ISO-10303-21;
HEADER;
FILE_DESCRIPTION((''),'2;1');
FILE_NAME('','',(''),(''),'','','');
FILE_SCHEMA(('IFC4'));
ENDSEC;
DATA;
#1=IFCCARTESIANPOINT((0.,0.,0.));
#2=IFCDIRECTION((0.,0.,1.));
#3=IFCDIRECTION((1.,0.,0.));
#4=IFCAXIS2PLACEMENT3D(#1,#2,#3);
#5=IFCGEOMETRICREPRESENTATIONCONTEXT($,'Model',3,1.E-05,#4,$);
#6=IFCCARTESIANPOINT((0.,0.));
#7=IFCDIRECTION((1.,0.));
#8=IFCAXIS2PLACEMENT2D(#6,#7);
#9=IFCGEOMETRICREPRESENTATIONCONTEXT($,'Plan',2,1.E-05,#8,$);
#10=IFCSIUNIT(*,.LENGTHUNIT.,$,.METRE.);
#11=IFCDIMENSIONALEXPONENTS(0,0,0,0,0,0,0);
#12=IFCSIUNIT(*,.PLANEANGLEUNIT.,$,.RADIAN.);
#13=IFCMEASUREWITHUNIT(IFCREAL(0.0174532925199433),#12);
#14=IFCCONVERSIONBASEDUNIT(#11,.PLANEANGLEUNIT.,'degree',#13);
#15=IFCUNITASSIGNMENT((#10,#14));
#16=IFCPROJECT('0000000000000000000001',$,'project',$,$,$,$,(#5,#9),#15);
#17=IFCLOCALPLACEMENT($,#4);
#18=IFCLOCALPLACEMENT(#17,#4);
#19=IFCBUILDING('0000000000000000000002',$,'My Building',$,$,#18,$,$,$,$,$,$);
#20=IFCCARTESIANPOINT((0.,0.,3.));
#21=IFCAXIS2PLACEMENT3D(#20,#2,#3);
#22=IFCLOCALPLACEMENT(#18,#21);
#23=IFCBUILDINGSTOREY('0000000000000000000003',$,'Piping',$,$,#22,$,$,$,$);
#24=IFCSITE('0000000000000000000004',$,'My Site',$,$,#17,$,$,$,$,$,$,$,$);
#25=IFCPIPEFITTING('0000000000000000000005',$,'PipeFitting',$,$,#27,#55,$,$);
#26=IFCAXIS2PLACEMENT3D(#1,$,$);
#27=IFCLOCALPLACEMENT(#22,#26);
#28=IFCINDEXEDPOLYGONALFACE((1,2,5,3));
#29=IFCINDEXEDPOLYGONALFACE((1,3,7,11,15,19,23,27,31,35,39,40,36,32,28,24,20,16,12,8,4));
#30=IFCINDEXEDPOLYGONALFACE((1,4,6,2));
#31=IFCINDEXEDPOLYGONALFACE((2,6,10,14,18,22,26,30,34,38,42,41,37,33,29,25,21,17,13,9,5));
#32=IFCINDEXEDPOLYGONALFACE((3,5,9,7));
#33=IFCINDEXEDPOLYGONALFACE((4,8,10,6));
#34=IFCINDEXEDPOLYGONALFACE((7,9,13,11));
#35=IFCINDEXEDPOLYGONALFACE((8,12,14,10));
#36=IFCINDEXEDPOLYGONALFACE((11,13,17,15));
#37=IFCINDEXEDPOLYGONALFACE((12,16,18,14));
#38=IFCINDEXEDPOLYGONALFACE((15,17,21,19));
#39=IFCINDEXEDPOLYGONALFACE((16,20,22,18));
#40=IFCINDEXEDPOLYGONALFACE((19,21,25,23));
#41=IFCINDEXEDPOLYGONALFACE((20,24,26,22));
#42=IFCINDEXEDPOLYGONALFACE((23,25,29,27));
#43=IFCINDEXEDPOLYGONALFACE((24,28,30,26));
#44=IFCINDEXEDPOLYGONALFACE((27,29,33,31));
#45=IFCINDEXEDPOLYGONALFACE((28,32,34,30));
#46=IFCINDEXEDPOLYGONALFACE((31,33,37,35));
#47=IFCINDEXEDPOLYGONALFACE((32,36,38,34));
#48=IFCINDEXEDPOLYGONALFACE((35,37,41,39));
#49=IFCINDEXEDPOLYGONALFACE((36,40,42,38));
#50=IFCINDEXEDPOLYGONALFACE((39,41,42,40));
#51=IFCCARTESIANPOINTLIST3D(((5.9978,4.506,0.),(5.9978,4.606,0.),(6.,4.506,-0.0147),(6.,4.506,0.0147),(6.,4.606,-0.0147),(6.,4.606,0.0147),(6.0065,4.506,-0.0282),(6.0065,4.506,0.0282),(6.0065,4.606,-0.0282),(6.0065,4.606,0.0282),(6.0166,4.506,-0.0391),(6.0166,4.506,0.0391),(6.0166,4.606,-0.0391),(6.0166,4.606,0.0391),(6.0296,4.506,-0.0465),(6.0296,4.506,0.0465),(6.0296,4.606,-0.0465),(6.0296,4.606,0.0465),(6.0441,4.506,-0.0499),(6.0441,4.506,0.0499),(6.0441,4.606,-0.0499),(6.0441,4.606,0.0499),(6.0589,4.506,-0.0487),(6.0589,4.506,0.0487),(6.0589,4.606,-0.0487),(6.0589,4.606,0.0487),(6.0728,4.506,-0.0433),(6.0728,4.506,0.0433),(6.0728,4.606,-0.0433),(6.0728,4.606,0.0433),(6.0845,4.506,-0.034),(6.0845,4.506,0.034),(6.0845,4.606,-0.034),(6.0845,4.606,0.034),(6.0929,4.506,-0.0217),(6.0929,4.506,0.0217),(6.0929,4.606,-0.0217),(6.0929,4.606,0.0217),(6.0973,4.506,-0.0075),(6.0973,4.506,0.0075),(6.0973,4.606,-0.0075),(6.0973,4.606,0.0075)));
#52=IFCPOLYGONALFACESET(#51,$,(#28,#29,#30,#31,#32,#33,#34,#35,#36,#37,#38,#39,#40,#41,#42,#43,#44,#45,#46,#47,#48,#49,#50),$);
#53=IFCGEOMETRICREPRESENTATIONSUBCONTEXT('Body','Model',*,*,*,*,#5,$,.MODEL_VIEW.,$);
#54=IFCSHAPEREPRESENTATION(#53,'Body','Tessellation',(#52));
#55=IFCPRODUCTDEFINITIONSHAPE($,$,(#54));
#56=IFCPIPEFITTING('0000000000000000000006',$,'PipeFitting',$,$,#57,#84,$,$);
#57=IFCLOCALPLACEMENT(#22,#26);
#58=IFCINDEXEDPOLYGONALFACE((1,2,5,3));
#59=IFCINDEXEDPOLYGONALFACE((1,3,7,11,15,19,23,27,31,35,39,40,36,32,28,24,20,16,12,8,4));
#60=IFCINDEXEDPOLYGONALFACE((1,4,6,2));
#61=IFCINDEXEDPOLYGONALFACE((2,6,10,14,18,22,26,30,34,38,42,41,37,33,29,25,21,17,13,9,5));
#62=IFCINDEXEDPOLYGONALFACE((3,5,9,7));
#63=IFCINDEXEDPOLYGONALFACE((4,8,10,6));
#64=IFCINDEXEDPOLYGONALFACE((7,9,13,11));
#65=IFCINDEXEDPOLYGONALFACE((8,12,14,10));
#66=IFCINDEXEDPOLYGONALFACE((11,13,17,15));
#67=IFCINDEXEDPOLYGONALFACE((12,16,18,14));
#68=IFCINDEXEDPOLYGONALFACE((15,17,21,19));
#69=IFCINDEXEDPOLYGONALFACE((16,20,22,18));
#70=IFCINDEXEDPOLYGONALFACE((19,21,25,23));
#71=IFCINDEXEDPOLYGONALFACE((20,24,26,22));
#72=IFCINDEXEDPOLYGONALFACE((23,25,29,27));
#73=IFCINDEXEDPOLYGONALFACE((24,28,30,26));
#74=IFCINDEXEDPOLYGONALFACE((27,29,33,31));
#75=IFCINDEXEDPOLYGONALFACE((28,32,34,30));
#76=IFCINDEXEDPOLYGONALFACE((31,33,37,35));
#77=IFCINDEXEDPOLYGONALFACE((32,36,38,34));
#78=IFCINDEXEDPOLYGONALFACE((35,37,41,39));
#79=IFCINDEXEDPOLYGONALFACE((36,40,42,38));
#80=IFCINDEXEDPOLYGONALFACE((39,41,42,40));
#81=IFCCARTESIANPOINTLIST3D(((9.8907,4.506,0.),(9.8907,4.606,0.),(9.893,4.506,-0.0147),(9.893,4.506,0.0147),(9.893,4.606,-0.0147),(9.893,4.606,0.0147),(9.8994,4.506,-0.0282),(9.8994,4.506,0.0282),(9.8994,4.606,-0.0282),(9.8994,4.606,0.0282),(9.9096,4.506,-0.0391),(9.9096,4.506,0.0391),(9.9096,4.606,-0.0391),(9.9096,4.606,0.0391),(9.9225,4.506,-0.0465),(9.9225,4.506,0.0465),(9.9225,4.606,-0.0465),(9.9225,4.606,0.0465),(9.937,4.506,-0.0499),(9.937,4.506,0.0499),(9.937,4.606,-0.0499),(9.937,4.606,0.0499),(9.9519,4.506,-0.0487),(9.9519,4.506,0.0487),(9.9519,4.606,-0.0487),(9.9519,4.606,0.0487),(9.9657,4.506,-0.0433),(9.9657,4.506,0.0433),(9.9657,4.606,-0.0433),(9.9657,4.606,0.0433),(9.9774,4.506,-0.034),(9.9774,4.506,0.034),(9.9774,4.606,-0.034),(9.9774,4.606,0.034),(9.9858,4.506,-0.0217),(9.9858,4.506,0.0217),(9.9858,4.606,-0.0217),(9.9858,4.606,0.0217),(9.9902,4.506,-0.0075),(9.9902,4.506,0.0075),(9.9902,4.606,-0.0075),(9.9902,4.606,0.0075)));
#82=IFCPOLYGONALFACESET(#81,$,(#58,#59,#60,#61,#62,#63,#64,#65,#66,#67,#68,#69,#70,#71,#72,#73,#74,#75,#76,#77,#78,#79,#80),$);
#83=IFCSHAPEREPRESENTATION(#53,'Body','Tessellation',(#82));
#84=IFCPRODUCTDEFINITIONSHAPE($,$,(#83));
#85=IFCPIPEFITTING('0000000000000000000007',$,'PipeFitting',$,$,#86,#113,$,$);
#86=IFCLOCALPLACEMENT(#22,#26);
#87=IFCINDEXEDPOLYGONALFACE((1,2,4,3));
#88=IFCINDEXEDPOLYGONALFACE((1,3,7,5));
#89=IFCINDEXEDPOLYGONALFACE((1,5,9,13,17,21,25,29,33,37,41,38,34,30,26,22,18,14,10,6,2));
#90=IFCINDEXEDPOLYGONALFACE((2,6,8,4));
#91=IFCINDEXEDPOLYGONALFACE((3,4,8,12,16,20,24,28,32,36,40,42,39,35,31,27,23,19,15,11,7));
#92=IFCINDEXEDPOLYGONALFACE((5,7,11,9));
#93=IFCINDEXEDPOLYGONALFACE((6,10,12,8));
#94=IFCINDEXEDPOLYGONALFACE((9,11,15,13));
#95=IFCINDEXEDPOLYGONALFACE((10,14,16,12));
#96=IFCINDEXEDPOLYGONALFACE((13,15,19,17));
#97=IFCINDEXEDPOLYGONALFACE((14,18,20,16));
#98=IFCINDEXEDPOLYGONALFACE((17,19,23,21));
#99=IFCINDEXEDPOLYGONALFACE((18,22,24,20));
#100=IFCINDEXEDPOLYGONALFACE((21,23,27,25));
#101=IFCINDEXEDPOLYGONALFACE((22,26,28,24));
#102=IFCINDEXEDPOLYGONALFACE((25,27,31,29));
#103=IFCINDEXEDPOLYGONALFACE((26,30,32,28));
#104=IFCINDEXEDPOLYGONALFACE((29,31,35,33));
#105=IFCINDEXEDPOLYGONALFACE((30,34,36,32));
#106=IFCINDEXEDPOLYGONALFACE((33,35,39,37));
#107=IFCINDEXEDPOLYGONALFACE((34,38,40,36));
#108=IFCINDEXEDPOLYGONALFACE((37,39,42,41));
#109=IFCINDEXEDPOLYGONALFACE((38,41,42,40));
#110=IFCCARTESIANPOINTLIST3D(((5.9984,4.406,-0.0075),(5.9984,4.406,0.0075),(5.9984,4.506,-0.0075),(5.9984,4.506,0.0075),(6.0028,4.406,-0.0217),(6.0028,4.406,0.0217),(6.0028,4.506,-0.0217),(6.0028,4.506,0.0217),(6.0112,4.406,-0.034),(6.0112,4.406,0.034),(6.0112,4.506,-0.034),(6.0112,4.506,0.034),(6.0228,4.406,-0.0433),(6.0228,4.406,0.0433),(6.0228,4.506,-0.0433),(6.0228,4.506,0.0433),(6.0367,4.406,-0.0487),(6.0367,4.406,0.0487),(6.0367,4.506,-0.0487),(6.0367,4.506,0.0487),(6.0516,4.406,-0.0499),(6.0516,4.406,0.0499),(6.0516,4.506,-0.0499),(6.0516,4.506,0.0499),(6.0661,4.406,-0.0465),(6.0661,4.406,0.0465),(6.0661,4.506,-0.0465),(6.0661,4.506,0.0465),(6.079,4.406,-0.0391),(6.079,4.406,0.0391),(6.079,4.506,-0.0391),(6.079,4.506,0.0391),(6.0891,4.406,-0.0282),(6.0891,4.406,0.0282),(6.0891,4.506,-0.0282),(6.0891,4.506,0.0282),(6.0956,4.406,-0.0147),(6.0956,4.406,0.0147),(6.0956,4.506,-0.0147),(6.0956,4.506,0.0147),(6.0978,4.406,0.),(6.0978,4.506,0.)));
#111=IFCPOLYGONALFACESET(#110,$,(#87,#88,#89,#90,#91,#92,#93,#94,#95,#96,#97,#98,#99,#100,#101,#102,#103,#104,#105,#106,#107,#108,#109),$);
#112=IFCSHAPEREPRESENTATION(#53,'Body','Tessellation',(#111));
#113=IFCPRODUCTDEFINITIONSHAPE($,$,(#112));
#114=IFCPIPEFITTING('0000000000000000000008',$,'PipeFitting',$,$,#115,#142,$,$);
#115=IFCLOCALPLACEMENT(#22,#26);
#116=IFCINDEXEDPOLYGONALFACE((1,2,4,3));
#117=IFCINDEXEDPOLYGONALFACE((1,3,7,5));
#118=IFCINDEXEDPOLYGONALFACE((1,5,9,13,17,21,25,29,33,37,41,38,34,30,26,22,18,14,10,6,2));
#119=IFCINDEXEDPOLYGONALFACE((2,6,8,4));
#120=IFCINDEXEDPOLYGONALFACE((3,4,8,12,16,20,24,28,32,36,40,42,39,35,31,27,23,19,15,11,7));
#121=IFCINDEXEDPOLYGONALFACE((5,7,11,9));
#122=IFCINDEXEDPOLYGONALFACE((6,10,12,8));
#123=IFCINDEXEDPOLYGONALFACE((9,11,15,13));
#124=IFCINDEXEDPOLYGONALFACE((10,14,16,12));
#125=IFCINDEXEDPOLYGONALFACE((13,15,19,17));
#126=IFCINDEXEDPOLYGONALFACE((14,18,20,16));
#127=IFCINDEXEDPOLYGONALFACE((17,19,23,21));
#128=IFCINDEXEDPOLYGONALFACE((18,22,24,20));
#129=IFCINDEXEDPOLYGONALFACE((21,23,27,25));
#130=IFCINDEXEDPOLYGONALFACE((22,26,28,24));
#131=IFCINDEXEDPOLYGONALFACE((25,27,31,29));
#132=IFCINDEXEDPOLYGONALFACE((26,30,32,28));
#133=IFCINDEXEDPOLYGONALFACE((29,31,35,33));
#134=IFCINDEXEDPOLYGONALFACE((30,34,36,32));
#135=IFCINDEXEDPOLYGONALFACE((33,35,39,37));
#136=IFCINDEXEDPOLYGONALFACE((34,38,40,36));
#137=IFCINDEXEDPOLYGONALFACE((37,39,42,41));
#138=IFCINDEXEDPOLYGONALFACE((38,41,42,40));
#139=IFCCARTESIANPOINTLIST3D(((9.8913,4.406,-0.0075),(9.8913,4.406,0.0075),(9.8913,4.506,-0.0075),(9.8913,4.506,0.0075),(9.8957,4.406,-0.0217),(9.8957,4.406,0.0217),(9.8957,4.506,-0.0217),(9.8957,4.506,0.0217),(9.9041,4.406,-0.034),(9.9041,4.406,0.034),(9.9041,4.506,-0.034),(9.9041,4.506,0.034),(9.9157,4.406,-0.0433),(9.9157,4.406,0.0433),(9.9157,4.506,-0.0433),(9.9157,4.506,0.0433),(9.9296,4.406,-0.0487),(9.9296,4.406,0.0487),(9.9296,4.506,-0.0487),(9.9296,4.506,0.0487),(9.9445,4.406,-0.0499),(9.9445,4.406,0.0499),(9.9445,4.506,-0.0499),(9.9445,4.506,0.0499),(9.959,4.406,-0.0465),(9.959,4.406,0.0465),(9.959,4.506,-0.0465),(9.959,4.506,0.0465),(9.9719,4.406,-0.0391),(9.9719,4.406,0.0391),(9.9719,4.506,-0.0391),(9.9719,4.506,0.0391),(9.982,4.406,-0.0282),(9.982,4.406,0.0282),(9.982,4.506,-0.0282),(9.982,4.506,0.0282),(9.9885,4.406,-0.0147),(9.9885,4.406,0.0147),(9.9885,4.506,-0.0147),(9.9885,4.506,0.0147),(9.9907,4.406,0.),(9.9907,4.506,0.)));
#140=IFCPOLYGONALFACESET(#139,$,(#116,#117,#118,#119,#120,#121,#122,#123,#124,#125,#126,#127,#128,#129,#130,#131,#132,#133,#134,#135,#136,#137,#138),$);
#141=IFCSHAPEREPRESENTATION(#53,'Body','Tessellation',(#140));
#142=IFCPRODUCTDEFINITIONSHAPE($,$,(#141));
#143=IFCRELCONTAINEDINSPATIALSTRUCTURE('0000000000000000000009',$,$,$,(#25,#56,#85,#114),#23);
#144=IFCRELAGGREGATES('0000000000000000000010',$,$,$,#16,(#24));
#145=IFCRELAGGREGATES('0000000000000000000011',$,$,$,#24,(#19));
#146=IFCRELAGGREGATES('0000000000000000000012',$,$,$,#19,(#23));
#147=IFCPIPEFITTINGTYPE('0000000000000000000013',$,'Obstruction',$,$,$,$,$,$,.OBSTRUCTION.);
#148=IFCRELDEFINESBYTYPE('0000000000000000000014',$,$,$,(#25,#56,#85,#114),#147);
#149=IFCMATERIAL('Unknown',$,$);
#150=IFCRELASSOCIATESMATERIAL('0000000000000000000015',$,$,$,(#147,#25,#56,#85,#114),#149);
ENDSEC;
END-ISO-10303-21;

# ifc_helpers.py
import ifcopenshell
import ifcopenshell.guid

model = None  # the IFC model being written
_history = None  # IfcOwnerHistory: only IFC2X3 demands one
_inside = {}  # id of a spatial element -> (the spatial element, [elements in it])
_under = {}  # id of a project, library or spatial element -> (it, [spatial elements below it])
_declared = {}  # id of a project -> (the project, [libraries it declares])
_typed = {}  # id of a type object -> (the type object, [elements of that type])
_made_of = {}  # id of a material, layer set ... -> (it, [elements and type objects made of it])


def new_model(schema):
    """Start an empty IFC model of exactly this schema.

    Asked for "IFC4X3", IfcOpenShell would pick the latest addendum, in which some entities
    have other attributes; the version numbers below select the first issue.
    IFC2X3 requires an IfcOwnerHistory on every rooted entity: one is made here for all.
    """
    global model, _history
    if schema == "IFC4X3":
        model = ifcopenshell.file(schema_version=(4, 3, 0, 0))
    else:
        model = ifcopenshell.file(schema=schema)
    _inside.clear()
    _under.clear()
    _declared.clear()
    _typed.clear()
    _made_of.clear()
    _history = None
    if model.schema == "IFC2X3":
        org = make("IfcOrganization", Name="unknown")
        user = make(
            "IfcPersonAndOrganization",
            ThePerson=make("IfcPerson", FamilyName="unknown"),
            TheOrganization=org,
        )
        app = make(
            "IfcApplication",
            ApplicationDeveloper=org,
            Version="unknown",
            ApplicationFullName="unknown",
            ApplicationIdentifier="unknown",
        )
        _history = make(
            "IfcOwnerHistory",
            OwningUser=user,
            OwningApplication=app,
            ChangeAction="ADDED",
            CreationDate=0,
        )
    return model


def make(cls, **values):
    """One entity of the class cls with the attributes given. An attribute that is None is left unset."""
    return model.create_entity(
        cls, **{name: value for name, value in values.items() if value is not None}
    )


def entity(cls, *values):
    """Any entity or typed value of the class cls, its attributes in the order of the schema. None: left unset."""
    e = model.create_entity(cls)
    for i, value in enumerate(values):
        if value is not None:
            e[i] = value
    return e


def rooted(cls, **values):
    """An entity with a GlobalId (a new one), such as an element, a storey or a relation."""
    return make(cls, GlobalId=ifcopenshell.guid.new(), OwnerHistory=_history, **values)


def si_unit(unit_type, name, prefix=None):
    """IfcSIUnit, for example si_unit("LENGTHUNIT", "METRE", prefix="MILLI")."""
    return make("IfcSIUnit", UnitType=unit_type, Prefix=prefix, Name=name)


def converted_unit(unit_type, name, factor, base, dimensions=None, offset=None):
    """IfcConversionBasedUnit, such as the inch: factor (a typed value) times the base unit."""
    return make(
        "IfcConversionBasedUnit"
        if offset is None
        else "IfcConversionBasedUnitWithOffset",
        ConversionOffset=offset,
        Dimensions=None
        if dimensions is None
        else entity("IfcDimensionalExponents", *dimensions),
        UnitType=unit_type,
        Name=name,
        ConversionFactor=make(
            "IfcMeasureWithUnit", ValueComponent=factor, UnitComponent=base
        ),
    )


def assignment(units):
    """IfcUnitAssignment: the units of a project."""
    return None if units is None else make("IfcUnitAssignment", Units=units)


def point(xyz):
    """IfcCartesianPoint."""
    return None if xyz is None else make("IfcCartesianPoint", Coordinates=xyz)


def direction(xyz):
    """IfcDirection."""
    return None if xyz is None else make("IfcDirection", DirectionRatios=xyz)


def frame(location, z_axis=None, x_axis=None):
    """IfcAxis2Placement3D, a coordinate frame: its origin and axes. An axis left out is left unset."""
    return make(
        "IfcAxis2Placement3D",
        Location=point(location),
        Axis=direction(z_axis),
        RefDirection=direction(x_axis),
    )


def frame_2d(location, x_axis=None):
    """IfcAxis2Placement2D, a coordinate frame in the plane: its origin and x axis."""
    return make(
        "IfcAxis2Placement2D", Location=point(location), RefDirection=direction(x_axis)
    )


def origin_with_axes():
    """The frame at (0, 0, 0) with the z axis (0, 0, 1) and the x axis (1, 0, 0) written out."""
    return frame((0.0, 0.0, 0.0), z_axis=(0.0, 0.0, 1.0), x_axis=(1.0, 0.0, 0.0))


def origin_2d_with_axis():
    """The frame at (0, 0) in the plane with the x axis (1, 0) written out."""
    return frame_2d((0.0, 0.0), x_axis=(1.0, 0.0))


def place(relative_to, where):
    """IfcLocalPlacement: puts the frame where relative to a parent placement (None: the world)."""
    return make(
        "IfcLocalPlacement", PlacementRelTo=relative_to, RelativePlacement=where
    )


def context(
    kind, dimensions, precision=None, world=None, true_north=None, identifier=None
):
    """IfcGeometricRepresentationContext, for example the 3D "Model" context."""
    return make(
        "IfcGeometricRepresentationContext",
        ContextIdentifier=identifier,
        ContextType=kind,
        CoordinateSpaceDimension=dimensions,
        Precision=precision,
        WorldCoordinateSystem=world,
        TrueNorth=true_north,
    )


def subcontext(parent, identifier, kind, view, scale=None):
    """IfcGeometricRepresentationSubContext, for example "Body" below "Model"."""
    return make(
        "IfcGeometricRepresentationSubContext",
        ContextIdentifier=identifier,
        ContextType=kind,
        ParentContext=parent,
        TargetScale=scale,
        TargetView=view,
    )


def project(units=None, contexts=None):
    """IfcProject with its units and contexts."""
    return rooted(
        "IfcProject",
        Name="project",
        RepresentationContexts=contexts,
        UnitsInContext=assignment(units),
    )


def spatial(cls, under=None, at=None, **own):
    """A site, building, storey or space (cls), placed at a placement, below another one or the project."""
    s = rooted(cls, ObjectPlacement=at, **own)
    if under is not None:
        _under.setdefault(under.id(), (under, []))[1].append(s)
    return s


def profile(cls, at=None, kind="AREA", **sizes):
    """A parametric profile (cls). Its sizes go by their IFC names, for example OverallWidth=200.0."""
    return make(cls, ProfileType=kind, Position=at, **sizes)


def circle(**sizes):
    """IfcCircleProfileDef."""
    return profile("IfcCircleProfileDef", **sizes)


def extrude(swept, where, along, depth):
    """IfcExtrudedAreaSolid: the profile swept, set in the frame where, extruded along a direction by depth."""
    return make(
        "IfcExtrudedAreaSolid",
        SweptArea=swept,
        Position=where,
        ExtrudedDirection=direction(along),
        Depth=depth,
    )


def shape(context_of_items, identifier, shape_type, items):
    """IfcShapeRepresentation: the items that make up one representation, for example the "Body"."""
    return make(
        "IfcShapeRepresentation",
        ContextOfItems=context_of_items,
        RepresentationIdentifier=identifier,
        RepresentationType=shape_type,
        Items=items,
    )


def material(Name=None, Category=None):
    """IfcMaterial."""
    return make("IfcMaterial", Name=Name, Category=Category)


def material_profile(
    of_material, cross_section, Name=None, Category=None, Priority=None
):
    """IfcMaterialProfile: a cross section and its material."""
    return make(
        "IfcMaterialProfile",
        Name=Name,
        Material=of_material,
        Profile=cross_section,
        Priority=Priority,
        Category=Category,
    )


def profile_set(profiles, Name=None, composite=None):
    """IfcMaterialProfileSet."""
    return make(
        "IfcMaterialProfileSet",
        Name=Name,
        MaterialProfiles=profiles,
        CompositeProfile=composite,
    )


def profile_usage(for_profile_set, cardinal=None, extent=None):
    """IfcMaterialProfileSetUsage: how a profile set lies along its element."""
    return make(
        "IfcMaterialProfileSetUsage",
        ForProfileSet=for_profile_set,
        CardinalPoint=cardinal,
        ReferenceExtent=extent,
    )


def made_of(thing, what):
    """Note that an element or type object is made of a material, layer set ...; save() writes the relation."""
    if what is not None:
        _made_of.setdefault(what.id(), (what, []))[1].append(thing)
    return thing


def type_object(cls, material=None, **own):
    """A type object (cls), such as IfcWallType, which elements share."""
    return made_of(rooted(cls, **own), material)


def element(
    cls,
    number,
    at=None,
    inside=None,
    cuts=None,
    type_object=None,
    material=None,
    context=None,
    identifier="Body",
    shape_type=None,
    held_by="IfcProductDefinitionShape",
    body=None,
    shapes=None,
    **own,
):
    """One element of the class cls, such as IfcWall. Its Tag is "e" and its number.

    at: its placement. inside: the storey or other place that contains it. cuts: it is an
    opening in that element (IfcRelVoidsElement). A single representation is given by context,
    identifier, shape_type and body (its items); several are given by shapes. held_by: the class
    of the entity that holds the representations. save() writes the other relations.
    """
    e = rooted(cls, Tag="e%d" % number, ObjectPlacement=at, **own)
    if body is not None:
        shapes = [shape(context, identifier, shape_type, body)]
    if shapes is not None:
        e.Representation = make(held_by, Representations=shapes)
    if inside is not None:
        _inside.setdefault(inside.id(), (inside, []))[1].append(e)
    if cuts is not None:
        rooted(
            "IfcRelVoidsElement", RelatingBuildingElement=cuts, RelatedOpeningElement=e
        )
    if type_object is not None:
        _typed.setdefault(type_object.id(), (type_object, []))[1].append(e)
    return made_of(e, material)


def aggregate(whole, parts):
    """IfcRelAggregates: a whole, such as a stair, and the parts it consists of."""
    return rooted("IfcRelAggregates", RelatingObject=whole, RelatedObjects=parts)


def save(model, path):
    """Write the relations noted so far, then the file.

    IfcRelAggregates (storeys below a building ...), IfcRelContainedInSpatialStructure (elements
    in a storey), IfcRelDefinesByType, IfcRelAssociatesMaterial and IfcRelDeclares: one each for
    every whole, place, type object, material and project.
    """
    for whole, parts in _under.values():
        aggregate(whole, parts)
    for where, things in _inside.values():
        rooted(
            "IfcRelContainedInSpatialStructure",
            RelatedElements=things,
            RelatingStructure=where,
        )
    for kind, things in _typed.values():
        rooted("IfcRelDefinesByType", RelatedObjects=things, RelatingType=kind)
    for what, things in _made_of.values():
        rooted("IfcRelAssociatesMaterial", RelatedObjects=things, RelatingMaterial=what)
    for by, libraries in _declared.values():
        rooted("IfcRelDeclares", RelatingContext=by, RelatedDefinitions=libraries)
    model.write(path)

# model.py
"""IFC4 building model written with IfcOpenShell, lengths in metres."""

from ifc_helpers import new_model, entity, si_unit, converted_unit, frame, origin_with_axes, origin_2d_with_axis, place, context, subcontext, project, spatial, circle, extrude, material, material_profile, profile_set, profile_usage, type_object, element, save


model = new_model("IFC4")

# Units and contexts
model_context = context("Model", 3, precision=1e-05, world=origin_with_axes())
plan_context = context("Plan", 2, precision=1e-05, world=origin_2d_with_axis())
body_context = subcontext(model_context, "Body", "Model", "MODEL_VIEW")
ifc_project = project(units=[si_unit("LENGTHUNIT", "METRE"), converted_unit("PLANEANGLEUNIT", "degree", entity("IfcReal", 0.0174532925199433), si_unit("PLANEANGLEUNIT", "RADIAN"), dimensions=[0, 0, 0, 0, 0, 0, 0])], contexts=[model_context, plan_context])

# Site, building, storey
site_placement = place(None, origin_with_axes())
site = spatial("IfcSite", under=ifc_project, at=site_placement, Name="My Site")
building_placement = place(site_placement, origin_with_axes())
building = spatial("IfcBuilding", under=site, at=building_placement, Name="My Building")
storey_placement = place(building_placement, frame((0.0, 0.0, 3.0), z_axis=(0.0, 0.0, 1.0), x_axis=(1.0, 0.0, 0.0)))
storey = spatial("IfcBuildingStorey", under=building, at=storey_placement, Name="Piping")

# Shared definitions
ifc_material = material(Name="Unknown")

# Pipe fittings
ifc_material_profile_1 = material_profile(ifc_material, circle(Radius=0.05))
ifc_profile_set_1 = profile_set([ifc_material_profile_1])
pipe_fitting_type_1 = type_object("IfcPipeFittingType", Name="Obstruction", PredefinedType="OBSTRUCTION", material=ifc_profile_set_1)
ifc_profile_usage_1 = profile_usage(ifc_profile_set_1, cardinal=5)
pipe_fitting_1_placement = place(storey_placement, frame((6.0478, 4.506, 0.0), z_axis=(0.0, 1.0, 0.0), x_axis=(-1.0, 0.0, 0.0)))
element("IfcPipeFitting", 1, at=pipe_fitting_1_placement, inside=storey, type_object=pipe_fitting_type_1, material=ifc_profile_usage_1, Name="PipeFitting", context=body_context, shape_type="SweptSolid", body=[
    extrude(circle(Radius=0.05), origin_with_axes(), (0.0, 0.0, 1.0), 0.1),
])
ifc_profile_usage_2 = profile_usage(ifc_profile_set_1, cardinal=5)
pipe_fitting_2_placement = place(storey_placement, frame((9.9407, 4.506, 0.0), z_axis=(0.0, 1.0, 0.0), x_axis=(-1.0, 0.0, 0.0)))
element("IfcPipeFitting", 2, at=pipe_fitting_2_placement, inside=storey, type_object=pipe_fitting_type_1, material=ifc_profile_usage_2, Name="PipeFitting", context=body_context, shape_type="SweptSolid", body=[
    extrude(circle(Radius=0.05), origin_with_axes(), (0.0, 0.0, 1.0), 0.1),
])
ifc_profile_usage_3 = profile_usage(ifc_profile_set_1, cardinal=5)
pipe_fitting_3_placement = place(storey_placement, frame((6.0478, 4.506, 0.0), z_axis=(0.0, -1.0, 0.0), x_axis=(1.0, 0.0, 0.0)))
element("IfcPipeFitting", 3, at=pipe_fitting_3_placement, inside=storey, type_object=pipe_fitting_type_1, material=ifc_profile_usage_3, Name="PipeFitting", context=body_context, shape_type="SweptSolid", body=[
    extrude(circle(Radius=0.05), origin_with_axes(), (0.0, 0.0, 1.0), 0.1),
])
ifc_profile_usage_4 = profile_usage(ifc_profile_set_1, cardinal=5)
pipe_fitting_4_placement = place(storey_placement, frame((9.9407, 4.506, 0.0), z_axis=(0.0, -1.0, 0.0), x_axis=(1.0, 0.0, 0.0)))
element("IfcPipeFitting", 4, at=pipe_fitting_4_placement, inside=storey, type_object=pipe_fitting_type_1, material=ifc_profile_usage_4, Name="PipeFitting", context=body_context, shape_type="SweptSolid", body=[
    extrude(circle(Radius=0.05), origin_with_axes(), (0.0, 0.0, 1.0), 0.1),
])

save(model, "model.ifc")
